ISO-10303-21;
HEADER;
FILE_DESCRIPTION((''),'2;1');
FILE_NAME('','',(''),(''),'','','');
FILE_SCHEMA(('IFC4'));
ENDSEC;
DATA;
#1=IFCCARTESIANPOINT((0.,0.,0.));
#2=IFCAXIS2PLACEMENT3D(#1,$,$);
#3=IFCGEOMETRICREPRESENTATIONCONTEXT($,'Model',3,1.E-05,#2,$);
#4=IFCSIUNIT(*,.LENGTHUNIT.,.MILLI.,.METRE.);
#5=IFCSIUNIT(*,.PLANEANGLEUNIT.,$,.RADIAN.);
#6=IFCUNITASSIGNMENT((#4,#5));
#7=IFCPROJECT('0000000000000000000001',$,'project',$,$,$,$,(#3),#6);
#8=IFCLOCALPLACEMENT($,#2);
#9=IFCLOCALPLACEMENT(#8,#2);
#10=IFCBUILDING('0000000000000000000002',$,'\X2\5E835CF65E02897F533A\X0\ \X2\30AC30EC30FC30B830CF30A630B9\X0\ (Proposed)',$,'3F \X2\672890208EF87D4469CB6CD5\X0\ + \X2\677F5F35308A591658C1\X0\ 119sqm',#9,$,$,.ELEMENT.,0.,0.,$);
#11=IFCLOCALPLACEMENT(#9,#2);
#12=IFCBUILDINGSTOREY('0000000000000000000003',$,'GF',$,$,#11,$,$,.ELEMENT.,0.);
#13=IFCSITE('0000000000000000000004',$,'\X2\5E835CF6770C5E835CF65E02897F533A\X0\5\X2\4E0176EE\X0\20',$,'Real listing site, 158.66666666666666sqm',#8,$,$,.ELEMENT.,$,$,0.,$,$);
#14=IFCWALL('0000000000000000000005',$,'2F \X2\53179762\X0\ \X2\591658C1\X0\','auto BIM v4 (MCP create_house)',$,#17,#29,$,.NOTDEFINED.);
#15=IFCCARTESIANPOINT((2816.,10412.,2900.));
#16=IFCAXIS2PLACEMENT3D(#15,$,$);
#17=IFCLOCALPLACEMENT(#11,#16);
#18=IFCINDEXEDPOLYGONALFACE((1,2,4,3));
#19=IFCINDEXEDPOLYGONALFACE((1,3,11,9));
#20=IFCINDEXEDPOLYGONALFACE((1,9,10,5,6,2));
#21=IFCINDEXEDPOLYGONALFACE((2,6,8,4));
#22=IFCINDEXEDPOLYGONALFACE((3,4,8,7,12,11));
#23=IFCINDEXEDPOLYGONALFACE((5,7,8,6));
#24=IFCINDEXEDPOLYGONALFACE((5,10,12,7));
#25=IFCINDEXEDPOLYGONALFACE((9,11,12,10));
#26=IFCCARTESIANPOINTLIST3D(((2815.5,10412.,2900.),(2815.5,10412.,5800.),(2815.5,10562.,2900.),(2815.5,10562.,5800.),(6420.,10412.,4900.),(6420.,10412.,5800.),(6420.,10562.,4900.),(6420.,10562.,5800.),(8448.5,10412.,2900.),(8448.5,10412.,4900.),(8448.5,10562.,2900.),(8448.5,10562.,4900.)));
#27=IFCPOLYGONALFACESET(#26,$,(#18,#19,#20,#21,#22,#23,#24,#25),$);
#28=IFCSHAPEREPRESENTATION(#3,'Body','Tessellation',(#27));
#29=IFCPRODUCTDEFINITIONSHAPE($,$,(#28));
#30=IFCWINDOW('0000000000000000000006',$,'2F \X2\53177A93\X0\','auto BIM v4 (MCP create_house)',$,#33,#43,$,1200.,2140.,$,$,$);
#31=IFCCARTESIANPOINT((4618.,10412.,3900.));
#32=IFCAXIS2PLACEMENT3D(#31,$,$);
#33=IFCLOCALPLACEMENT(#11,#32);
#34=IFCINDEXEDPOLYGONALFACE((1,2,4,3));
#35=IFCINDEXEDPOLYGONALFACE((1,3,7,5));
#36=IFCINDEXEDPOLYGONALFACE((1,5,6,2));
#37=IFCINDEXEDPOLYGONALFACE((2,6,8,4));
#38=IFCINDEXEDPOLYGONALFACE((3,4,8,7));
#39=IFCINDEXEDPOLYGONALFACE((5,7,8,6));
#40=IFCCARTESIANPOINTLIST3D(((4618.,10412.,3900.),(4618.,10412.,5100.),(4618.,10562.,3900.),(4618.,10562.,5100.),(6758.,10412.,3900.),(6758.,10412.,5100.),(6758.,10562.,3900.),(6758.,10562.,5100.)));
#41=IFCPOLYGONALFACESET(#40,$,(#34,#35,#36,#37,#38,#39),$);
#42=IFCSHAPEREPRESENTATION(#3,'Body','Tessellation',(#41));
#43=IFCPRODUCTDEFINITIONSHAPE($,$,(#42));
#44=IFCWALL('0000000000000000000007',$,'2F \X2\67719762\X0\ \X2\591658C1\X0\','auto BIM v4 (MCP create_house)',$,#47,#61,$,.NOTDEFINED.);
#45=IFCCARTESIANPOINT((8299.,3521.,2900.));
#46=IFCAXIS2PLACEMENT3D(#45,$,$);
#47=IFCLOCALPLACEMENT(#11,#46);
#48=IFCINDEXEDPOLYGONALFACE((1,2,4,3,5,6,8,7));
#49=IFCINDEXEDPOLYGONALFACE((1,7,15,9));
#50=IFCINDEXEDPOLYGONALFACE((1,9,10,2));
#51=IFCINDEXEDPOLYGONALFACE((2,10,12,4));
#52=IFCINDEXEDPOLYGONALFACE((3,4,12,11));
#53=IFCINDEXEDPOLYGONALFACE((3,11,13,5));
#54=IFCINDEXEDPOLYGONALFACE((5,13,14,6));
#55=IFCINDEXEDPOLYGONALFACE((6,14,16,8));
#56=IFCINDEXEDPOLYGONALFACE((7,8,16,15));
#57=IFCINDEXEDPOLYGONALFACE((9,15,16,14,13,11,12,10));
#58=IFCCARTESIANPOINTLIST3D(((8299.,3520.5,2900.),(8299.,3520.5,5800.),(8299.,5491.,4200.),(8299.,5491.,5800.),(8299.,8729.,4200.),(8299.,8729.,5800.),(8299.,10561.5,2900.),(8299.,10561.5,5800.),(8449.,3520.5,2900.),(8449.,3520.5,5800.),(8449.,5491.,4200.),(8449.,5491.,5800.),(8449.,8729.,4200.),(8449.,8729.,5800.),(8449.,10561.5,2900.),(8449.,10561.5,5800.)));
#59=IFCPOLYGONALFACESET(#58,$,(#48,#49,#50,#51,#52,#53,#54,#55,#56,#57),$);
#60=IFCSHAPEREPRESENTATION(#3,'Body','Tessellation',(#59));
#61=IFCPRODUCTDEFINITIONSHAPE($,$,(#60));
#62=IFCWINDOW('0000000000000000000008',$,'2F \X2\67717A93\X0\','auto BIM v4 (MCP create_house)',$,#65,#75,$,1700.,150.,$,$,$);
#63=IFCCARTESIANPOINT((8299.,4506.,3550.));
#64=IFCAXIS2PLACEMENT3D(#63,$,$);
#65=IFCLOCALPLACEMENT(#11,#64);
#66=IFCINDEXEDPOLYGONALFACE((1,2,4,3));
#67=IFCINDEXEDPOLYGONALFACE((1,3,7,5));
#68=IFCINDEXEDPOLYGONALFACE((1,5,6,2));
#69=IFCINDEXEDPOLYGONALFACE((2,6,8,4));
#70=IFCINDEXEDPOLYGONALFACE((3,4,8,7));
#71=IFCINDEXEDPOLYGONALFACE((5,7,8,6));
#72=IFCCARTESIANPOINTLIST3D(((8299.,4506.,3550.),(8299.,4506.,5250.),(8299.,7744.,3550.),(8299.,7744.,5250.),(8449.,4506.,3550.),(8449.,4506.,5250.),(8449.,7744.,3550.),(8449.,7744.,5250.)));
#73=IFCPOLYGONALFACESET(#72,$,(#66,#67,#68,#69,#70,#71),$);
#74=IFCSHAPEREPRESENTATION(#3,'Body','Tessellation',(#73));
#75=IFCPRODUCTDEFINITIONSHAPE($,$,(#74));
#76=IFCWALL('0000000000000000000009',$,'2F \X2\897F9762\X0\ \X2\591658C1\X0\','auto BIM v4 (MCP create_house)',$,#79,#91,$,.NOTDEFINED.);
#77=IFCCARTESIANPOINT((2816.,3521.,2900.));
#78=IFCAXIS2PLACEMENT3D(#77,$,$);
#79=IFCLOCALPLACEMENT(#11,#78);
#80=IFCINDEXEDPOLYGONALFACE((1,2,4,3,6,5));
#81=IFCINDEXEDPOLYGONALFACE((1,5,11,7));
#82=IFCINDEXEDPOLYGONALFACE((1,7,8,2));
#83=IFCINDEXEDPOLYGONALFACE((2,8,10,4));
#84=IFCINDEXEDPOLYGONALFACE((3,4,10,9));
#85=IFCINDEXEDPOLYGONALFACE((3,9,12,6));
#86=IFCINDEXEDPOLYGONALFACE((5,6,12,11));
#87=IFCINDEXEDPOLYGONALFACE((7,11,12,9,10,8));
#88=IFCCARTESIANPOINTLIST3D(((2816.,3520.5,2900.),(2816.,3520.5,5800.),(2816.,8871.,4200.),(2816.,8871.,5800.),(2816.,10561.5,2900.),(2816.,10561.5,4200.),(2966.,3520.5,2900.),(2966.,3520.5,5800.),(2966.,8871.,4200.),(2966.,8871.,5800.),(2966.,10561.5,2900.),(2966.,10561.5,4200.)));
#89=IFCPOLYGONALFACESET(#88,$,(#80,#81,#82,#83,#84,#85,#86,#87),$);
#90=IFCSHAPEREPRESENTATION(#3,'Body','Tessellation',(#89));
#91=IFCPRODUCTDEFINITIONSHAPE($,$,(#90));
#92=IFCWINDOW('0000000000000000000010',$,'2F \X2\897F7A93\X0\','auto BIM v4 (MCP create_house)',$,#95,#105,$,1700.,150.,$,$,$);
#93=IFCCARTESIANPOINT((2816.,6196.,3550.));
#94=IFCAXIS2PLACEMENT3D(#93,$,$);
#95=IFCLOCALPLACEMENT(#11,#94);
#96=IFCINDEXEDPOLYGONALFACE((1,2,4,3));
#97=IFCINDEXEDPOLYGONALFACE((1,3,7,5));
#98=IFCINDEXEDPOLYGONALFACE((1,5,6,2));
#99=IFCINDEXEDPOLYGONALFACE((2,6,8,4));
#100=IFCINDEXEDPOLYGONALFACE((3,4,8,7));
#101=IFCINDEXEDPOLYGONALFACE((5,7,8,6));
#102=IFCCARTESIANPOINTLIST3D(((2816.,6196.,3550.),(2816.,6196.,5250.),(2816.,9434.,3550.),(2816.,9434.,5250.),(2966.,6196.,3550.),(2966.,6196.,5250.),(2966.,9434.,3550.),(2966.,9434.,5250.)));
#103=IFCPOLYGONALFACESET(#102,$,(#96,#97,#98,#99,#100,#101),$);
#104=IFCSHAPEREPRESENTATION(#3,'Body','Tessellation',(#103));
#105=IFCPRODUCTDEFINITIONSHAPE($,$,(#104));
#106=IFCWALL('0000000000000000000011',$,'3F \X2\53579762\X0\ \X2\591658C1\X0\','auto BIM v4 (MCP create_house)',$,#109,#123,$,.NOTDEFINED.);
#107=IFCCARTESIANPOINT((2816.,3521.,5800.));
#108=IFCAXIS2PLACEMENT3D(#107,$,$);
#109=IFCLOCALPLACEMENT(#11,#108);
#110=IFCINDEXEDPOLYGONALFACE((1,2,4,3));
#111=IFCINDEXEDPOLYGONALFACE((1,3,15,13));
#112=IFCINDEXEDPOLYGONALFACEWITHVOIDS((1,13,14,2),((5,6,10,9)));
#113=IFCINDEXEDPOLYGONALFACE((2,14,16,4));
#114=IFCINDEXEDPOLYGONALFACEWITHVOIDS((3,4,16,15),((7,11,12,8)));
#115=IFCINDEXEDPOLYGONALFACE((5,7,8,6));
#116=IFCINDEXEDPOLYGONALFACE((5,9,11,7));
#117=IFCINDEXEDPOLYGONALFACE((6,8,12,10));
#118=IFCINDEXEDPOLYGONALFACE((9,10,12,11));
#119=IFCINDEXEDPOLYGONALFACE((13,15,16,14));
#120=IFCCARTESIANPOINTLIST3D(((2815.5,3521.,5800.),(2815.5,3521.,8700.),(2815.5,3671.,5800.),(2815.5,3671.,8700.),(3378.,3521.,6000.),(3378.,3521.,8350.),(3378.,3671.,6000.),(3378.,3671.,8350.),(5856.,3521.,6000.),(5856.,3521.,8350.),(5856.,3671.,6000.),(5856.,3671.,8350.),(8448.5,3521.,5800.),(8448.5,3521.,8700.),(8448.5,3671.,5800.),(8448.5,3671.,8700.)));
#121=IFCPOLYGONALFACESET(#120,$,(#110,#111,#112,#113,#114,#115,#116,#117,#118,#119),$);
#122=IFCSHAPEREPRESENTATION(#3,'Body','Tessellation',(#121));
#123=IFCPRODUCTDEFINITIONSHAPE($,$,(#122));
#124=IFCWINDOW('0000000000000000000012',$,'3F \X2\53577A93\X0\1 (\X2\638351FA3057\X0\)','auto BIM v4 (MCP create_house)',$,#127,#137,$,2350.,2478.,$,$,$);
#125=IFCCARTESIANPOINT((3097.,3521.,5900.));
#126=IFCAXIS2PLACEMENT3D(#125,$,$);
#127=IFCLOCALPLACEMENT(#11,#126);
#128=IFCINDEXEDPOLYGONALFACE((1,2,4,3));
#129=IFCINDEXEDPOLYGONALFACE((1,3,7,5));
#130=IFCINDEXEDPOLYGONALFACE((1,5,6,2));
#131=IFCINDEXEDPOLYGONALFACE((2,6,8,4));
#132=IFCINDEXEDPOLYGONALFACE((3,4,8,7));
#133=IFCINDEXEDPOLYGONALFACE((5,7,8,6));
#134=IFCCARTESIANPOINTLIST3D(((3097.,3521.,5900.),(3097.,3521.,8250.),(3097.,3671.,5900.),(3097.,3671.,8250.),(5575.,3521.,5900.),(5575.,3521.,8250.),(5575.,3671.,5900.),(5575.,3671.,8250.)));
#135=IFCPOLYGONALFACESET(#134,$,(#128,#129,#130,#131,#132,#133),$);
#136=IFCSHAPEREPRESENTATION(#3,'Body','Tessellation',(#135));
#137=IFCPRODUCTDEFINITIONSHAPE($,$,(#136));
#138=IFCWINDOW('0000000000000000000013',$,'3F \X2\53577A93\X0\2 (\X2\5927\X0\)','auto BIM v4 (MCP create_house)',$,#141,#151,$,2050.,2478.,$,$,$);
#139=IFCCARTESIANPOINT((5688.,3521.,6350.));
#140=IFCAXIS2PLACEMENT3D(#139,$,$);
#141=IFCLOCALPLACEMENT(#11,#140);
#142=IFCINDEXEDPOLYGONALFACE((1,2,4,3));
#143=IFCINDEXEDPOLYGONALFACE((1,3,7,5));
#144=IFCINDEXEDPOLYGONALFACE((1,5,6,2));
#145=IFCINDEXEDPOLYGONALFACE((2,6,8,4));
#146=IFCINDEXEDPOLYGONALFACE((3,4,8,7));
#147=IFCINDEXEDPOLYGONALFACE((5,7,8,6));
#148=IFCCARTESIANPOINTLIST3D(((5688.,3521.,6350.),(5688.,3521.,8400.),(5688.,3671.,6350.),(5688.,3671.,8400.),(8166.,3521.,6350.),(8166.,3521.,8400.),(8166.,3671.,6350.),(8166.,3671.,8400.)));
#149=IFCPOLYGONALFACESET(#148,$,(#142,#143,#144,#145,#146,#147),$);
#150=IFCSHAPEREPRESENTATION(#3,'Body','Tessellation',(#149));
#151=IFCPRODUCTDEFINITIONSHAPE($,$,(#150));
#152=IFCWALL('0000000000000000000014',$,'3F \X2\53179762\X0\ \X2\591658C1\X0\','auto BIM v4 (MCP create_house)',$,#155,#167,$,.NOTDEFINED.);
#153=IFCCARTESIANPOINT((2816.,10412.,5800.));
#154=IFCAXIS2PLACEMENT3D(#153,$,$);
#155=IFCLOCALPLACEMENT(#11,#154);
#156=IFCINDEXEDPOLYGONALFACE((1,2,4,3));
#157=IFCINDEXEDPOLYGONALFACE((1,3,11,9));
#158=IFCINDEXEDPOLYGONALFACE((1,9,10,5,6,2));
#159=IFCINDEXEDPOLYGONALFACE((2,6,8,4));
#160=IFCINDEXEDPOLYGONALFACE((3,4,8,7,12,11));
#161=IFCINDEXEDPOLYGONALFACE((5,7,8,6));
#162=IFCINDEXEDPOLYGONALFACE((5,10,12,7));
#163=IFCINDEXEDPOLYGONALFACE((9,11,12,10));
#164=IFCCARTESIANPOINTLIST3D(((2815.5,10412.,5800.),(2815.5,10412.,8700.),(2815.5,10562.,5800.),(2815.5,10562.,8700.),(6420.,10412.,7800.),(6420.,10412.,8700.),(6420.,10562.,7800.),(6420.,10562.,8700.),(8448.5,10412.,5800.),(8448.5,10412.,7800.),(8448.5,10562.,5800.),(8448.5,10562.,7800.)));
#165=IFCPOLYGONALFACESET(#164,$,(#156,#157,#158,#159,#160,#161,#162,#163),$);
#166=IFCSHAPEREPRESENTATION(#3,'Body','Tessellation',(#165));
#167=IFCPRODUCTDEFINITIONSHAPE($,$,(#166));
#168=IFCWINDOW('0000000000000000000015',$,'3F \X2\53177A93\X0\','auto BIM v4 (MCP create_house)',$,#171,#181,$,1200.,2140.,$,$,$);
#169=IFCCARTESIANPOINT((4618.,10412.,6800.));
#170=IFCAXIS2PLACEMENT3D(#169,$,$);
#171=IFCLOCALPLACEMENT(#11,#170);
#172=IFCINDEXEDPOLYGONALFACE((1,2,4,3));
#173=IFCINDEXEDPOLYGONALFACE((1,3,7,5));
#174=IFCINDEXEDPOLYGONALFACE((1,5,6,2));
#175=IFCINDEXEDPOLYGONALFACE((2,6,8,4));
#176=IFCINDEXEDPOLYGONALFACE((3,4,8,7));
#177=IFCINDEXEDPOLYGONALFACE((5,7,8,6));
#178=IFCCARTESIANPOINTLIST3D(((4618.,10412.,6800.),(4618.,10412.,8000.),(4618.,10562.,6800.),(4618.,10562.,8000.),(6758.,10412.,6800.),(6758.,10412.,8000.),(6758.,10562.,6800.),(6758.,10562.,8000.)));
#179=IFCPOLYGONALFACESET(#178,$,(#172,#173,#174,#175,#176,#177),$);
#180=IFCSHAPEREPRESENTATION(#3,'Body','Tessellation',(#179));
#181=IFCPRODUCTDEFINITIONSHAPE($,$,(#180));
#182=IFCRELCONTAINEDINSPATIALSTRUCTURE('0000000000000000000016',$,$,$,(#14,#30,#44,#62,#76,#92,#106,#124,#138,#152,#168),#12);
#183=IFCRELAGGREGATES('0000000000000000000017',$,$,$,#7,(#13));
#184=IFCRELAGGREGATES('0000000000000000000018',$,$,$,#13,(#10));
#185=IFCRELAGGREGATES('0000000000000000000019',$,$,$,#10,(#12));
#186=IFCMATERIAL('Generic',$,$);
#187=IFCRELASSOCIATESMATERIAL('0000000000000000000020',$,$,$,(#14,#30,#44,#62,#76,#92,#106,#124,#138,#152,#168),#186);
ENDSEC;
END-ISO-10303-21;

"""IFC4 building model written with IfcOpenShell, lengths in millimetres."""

from ifc_helpers import new_model, si_unit, frame, frame_2d, origin, place, context, project, spatial, rectangle, extrude, material, element, fill, save


model = new_model("IFC4")

# Units and contexts
model_context = context("Model", 3, precision=1e-05, world=origin())
ifc_project = project(units=[si_unit("LENGTHUNIT", "METRE", prefix="MILLI"), si_unit("PLANEANGLEUNIT", "RADIAN")], contexts=[model_context])

# Site, building, storey
site_placement = place(None, origin())
site = spatial("IfcSite", under=ifc_project, at=site_placement, Name="広島県広島市西区5丁目20", ObjectType="Real listing site, 158.66666666666666sqm", CompositionType="ELEMENT", RefElevation=0.0)
building_placement = place(site_placement, origin())
building = spatial("IfcBuilding", under=site, at=building_placement, Name="広島市西区 ガレージハウス (Proposed)", ObjectType="3F 木造軸組構法 + 板張り外壁 119sqm", CompositionType="ELEMENT", ElevationOfRefHeight=0.0, ElevationOfTerrain=0.0)
storey_placement = place(building_placement, origin())
storey = spatial("IfcBuildingStorey", under=building, at=storey_placement, Name="GF", CompositionType="ELEMENT", Elevation=0.0)

# Shared definitions
ifc_material = material(Name="Generic")

# Walls, openings, windows
wall_1_placement = place(storey_placement, frame((2816.0, 10412.0, 2900.0)))
wall_1 = element("IfcWall", 1, at=wall_1_placement, inside=storey, material=ifc_material, Name="2F 北面 外壁", Description="auto BIM v4 (MCP create_house)", PredefinedType="NOTDEFINED", context=model_context, shape_type="SweptSolid", body=[
    extrude(rectangle(XDim=5633.0, YDim=150.0, at=frame_2d((2816.0, 75.0))), frame((2816.0, 10412.0, 2900.0)), (0.0, 0.0, 1.0), 2900.0),
])
opening_1_placement = place(storey_placement, frame((4618.0, 10412.0, 3900.0)))
opening_1 = element("IfcOpeningElement", 2, at=opening_1_placement, cuts=wall_1, PredefinedType="NOTDEFINED", context=model_context, shape_type="SweptSolid", body=[
    extrude(rectangle(XDim=2140.0, YDim=150.0, at=frame_2d((1070.0, 75.0))), frame((4618.0, 10412.0, 3900.0)), (0.0, 0.0, 1.0), 1200.0),
])
window_1_placement = place(storey_placement, frame((4618.0, 10412.0, 3900.0)))
window_1 = element("IfcWindow", 3, at=window_1_placement, inside=storey, material=ifc_material, Name="2F 北窓", Description="auto BIM v4 (MCP create_house)", OverallHeight=1200.0, OverallWidth=2140.0, context=model_context, shape_type="SweptSolid", body=[
    extrude(rectangle(XDim=2140.0, YDim=150.0, at=frame_2d((1070.0, 75.0))), frame((4618.0, 10412.0, 3900.0)), (0.0, 0.0, 1.0), 1200.0),
])
fill(opening_1, window_1)
wall_2_placement = place(storey_placement, frame((8299.0, 3521.0, 2900.0)))
wall_2 = element("IfcWall", 4, at=wall_2_placement, inside=storey, material=ifc_material, Name="2F 東面 外壁", Description="auto BIM v4 (MCP create_house)", PredefinedType="NOTDEFINED", context=model_context, shape_type="SweptSolid", body=[
    extrude(rectangle(XDim=150.0, YDim=7041.0, at=frame_2d((75.0, 3520.0))), frame((8299.0, 3521.0, 2900.0)), (0.0, 0.0, 1.0), 2900.0),
])
opening_2_placement = place(storey_placement, frame((8299.0, 4506.0, 3550.0)))
opening_2 = element("IfcOpeningElement", 5, at=opening_2_placement, cuts=wall_2, PredefinedType="NOTDEFINED", context=model_context, shape_type="SweptSolid", body=[
    extrude(rectangle(XDim=150.0, YDim=3238.0, at=frame_2d((75.0, 1619.0))), frame((8299.0, 4506.0, 3550.0)), (0.0, 0.0, 1.0), 1700.0),
])
window_2_placement = place(storey_placement, frame((8299.0, 4506.0, 3550.0)))
window_2 = element("IfcWindow", 6, at=window_2_placement, inside=storey, material=ifc_material, Name="2F 東窓", Description="auto BIM v4 (MCP create_house)", OverallHeight=1700.0, OverallWidth=150.0, context=model_context, shape_type="SweptSolid", body=[
    extrude(rectangle(XDim=150.0, YDim=3238.0, at=frame_2d((75.0, 1619.0))), frame((8299.0, 4506.0, 3550.0)), (0.0, 0.0, 1.0), 1700.0),
])
fill(opening_2, window_2)
wall_3_placement = place(storey_placement, frame((2816.0, 3521.0, 2900.0)))
wall_3 = element("IfcWall", 7, at=wall_3_placement, inside=storey, material=ifc_material, Name="2F 西面 外壁", Description="auto BIM v4 (MCP create_house)", PredefinedType="NOTDEFINED", context=model_context, shape_type="SweptSolid", body=[
    extrude(rectangle(XDim=150.0, YDim=7041.0, at=frame_2d((75.0, 3520.0))), frame((2816.0, 3521.0, 2900.0)), (0.0, 0.0, 1.0), 2900.0),
])
opening_3_placement = place(storey_placement, frame((2816.0, 6196.0, 3550.0)))
opening_3 = element("IfcOpeningElement", 8, at=opening_3_placement, cuts=wall_3, PredefinedType="NOTDEFINED", context=model_context, shape_type="SweptSolid", body=[
    extrude(rectangle(XDim=150.0, YDim=3238.0, at=frame_2d((75.0, 1619.0))), frame((2816.0, 6196.0, 3550.0)), (0.0, 0.0, 1.0), 1700.0),
])
window_3_placement = place(storey_placement, frame((2816.0, 6196.0, 3550.0)))
window_3 = element("IfcWindow", 9, at=window_3_placement, inside=storey, material=ifc_material, Name="2F 西窓", Description="auto BIM v4 (MCP create_house)", OverallHeight=1700.0, OverallWidth=150.0, context=model_context, shape_type="SweptSolid", body=[
    extrude(rectangle(XDim=150.0, YDim=3238.0, at=frame_2d((75.0, 1619.0))), frame((2816.0, 6196.0, 3550.0)), (0.0, 0.0, 1.0), 1700.0),
])
fill(opening_3, window_3)

# Wall, openings, windows
wall_4_placement = place(storey_placement, frame((2816.0, 3521.0, 5800.0)))
wall_4 = element("IfcWall", 10, at=wall_4_placement, inside=storey, material=ifc_material, Name="3F 南面 外壁", Description="auto BIM v4 (MCP create_house)", PredefinedType="NOTDEFINED", context=model_context, shape_type="SweptSolid", body=[
    extrude(rectangle(XDim=5633.0, YDim=150.0, at=frame_2d((2816.0, 75.0))), frame((2816.0, 3521.0, 5800.0)), (0.0, 0.0, 1.0), 2900.0),
])
opening_4_placement = place(storey_placement, frame((3097.0, 3521.0, 5900.0)))
opening_4 = element("IfcOpeningElement", 11, at=opening_4_placement, cuts=wall_4, PredefinedType="NOTDEFINED", context=model_context, shape_type="SweptSolid", body=[
    extrude(rectangle(XDim=2478.0, YDim=150.0, at=frame_2d((1239.0, 75.0))), frame((3097.0, 3521.0, 5900.0)), (0.0, 0.0, 1.0), 2350.0),
])
opening_5_placement = place(storey_placement, frame((5688.0, 3521.0, 6350.0)))
opening_5 = element("IfcOpeningElement", 12, at=opening_5_placement, cuts=wall_4, PredefinedType="NOTDEFINED", context=model_context, shape_type="SweptSolid", body=[
    extrude(rectangle(XDim=2478.0, YDim=150.0, at=frame_2d((1239.0, 75.0))), frame((5688.0, 3521.0, 6350.0)), (0.0, 0.0, 1.0), 2050.0),
])
window_4_placement = place(storey_placement, frame((3097.0, 3521.0, 5900.0)))
window_4 = element("IfcWindow", 13, at=window_4_placement, inside=storey, material=ifc_material, Name="3F 南窓1 (掃出し)", Description="auto BIM v4 (MCP create_house)", OverallHeight=2350.0, OverallWidth=2478.0, context=model_context, shape_type="SweptSolid", body=[
    extrude(rectangle(XDim=2478.0, YDim=150.0, at=frame_2d((1239.0, 75.0))), frame((3097.0, 3521.0, 5900.0)), (0.0, 0.0, 1.0), 2350.0),
])
fill(opening_4, window_4)
window_5_placement = place(storey_placement, frame((5688.0, 3521.0, 6350.0)))
window_5 = element("IfcWindow", 14, at=window_5_placement, inside=storey, material=ifc_material, Name="3F 南窓2 (大)", Description="auto BIM v4 (MCP create_house)", OverallHeight=2050.0, OverallWidth=2478.0, context=model_context, shape_type="SweptSolid", body=[
    extrude(rectangle(XDim=2478.0, YDim=150.0, at=frame_2d((1239.0, 75.0))), frame((5688.0, 3521.0, 6350.0)), (0.0, 0.0, 1.0), 2050.0),
])
fill(opening_5, window_5)

# Wall, opening, window
wall_5_placement = place(storey_placement, frame((2816.0, 10412.0, 5800.0)))
wall_5 = element("IfcWall", 15, at=wall_5_placement, inside=storey, material=ifc_material, Name="3F 北面 外壁", Description="auto BIM v4 (MCP create_house)", PredefinedType="NOTDEFINED", context=model_context, shape_type="SweptSolid", body=[
    extrude(rectangle(XDim=5633.0, YDim=150.0, at=frame_2d((2816.0, 75.0))), frame((2816.0, 10412.0, 5800.0)), (0.0, 0.0, 1.0), 2900.0),
])
opening_6_placement = place(storey_placement, frame((4618.0, 10412.0, 6800.0)))
opening_6 = element("IfcOpeningElement", 16, at=opening_6_placement, cuts=wall_5, PredefinedType="NOTDEFINED", context=model_context, shape_type="SweptSolid", body=[
    extrude(rectangle(XDim=2140.0, YDim=150.0, at=frame_2d((1070.0, 75.0))), frame((4618.0, 10412.0, 6800.0)), (0.0, 0.0, 1.0), 1200.0),
])
window_6_placement = place(storey_placement, frame((4618.0, 10412.0, 6800.0)))
window_6 = element("IfcWindow", 17, at=window_6_placement, inside=storey, material=ifc_material, Name="3F 北窓", Description="auto BIM v4 (MCP create_house)", OverallHeight=1200.0, OverallWidth=2140.0, context=model_context, shape_type="SweptSolid", body=[
    extrude(rectangle(XDim=2140.0, YDim=150.0, at=frame_2d((1070.0, 75.0))), frame((4618.0, 10412.0, 6800.0)), (0.0, 0.0, 1.0), 1200.0),
])
fill(opening_6, window_6)

save(model, "model.ifc")
